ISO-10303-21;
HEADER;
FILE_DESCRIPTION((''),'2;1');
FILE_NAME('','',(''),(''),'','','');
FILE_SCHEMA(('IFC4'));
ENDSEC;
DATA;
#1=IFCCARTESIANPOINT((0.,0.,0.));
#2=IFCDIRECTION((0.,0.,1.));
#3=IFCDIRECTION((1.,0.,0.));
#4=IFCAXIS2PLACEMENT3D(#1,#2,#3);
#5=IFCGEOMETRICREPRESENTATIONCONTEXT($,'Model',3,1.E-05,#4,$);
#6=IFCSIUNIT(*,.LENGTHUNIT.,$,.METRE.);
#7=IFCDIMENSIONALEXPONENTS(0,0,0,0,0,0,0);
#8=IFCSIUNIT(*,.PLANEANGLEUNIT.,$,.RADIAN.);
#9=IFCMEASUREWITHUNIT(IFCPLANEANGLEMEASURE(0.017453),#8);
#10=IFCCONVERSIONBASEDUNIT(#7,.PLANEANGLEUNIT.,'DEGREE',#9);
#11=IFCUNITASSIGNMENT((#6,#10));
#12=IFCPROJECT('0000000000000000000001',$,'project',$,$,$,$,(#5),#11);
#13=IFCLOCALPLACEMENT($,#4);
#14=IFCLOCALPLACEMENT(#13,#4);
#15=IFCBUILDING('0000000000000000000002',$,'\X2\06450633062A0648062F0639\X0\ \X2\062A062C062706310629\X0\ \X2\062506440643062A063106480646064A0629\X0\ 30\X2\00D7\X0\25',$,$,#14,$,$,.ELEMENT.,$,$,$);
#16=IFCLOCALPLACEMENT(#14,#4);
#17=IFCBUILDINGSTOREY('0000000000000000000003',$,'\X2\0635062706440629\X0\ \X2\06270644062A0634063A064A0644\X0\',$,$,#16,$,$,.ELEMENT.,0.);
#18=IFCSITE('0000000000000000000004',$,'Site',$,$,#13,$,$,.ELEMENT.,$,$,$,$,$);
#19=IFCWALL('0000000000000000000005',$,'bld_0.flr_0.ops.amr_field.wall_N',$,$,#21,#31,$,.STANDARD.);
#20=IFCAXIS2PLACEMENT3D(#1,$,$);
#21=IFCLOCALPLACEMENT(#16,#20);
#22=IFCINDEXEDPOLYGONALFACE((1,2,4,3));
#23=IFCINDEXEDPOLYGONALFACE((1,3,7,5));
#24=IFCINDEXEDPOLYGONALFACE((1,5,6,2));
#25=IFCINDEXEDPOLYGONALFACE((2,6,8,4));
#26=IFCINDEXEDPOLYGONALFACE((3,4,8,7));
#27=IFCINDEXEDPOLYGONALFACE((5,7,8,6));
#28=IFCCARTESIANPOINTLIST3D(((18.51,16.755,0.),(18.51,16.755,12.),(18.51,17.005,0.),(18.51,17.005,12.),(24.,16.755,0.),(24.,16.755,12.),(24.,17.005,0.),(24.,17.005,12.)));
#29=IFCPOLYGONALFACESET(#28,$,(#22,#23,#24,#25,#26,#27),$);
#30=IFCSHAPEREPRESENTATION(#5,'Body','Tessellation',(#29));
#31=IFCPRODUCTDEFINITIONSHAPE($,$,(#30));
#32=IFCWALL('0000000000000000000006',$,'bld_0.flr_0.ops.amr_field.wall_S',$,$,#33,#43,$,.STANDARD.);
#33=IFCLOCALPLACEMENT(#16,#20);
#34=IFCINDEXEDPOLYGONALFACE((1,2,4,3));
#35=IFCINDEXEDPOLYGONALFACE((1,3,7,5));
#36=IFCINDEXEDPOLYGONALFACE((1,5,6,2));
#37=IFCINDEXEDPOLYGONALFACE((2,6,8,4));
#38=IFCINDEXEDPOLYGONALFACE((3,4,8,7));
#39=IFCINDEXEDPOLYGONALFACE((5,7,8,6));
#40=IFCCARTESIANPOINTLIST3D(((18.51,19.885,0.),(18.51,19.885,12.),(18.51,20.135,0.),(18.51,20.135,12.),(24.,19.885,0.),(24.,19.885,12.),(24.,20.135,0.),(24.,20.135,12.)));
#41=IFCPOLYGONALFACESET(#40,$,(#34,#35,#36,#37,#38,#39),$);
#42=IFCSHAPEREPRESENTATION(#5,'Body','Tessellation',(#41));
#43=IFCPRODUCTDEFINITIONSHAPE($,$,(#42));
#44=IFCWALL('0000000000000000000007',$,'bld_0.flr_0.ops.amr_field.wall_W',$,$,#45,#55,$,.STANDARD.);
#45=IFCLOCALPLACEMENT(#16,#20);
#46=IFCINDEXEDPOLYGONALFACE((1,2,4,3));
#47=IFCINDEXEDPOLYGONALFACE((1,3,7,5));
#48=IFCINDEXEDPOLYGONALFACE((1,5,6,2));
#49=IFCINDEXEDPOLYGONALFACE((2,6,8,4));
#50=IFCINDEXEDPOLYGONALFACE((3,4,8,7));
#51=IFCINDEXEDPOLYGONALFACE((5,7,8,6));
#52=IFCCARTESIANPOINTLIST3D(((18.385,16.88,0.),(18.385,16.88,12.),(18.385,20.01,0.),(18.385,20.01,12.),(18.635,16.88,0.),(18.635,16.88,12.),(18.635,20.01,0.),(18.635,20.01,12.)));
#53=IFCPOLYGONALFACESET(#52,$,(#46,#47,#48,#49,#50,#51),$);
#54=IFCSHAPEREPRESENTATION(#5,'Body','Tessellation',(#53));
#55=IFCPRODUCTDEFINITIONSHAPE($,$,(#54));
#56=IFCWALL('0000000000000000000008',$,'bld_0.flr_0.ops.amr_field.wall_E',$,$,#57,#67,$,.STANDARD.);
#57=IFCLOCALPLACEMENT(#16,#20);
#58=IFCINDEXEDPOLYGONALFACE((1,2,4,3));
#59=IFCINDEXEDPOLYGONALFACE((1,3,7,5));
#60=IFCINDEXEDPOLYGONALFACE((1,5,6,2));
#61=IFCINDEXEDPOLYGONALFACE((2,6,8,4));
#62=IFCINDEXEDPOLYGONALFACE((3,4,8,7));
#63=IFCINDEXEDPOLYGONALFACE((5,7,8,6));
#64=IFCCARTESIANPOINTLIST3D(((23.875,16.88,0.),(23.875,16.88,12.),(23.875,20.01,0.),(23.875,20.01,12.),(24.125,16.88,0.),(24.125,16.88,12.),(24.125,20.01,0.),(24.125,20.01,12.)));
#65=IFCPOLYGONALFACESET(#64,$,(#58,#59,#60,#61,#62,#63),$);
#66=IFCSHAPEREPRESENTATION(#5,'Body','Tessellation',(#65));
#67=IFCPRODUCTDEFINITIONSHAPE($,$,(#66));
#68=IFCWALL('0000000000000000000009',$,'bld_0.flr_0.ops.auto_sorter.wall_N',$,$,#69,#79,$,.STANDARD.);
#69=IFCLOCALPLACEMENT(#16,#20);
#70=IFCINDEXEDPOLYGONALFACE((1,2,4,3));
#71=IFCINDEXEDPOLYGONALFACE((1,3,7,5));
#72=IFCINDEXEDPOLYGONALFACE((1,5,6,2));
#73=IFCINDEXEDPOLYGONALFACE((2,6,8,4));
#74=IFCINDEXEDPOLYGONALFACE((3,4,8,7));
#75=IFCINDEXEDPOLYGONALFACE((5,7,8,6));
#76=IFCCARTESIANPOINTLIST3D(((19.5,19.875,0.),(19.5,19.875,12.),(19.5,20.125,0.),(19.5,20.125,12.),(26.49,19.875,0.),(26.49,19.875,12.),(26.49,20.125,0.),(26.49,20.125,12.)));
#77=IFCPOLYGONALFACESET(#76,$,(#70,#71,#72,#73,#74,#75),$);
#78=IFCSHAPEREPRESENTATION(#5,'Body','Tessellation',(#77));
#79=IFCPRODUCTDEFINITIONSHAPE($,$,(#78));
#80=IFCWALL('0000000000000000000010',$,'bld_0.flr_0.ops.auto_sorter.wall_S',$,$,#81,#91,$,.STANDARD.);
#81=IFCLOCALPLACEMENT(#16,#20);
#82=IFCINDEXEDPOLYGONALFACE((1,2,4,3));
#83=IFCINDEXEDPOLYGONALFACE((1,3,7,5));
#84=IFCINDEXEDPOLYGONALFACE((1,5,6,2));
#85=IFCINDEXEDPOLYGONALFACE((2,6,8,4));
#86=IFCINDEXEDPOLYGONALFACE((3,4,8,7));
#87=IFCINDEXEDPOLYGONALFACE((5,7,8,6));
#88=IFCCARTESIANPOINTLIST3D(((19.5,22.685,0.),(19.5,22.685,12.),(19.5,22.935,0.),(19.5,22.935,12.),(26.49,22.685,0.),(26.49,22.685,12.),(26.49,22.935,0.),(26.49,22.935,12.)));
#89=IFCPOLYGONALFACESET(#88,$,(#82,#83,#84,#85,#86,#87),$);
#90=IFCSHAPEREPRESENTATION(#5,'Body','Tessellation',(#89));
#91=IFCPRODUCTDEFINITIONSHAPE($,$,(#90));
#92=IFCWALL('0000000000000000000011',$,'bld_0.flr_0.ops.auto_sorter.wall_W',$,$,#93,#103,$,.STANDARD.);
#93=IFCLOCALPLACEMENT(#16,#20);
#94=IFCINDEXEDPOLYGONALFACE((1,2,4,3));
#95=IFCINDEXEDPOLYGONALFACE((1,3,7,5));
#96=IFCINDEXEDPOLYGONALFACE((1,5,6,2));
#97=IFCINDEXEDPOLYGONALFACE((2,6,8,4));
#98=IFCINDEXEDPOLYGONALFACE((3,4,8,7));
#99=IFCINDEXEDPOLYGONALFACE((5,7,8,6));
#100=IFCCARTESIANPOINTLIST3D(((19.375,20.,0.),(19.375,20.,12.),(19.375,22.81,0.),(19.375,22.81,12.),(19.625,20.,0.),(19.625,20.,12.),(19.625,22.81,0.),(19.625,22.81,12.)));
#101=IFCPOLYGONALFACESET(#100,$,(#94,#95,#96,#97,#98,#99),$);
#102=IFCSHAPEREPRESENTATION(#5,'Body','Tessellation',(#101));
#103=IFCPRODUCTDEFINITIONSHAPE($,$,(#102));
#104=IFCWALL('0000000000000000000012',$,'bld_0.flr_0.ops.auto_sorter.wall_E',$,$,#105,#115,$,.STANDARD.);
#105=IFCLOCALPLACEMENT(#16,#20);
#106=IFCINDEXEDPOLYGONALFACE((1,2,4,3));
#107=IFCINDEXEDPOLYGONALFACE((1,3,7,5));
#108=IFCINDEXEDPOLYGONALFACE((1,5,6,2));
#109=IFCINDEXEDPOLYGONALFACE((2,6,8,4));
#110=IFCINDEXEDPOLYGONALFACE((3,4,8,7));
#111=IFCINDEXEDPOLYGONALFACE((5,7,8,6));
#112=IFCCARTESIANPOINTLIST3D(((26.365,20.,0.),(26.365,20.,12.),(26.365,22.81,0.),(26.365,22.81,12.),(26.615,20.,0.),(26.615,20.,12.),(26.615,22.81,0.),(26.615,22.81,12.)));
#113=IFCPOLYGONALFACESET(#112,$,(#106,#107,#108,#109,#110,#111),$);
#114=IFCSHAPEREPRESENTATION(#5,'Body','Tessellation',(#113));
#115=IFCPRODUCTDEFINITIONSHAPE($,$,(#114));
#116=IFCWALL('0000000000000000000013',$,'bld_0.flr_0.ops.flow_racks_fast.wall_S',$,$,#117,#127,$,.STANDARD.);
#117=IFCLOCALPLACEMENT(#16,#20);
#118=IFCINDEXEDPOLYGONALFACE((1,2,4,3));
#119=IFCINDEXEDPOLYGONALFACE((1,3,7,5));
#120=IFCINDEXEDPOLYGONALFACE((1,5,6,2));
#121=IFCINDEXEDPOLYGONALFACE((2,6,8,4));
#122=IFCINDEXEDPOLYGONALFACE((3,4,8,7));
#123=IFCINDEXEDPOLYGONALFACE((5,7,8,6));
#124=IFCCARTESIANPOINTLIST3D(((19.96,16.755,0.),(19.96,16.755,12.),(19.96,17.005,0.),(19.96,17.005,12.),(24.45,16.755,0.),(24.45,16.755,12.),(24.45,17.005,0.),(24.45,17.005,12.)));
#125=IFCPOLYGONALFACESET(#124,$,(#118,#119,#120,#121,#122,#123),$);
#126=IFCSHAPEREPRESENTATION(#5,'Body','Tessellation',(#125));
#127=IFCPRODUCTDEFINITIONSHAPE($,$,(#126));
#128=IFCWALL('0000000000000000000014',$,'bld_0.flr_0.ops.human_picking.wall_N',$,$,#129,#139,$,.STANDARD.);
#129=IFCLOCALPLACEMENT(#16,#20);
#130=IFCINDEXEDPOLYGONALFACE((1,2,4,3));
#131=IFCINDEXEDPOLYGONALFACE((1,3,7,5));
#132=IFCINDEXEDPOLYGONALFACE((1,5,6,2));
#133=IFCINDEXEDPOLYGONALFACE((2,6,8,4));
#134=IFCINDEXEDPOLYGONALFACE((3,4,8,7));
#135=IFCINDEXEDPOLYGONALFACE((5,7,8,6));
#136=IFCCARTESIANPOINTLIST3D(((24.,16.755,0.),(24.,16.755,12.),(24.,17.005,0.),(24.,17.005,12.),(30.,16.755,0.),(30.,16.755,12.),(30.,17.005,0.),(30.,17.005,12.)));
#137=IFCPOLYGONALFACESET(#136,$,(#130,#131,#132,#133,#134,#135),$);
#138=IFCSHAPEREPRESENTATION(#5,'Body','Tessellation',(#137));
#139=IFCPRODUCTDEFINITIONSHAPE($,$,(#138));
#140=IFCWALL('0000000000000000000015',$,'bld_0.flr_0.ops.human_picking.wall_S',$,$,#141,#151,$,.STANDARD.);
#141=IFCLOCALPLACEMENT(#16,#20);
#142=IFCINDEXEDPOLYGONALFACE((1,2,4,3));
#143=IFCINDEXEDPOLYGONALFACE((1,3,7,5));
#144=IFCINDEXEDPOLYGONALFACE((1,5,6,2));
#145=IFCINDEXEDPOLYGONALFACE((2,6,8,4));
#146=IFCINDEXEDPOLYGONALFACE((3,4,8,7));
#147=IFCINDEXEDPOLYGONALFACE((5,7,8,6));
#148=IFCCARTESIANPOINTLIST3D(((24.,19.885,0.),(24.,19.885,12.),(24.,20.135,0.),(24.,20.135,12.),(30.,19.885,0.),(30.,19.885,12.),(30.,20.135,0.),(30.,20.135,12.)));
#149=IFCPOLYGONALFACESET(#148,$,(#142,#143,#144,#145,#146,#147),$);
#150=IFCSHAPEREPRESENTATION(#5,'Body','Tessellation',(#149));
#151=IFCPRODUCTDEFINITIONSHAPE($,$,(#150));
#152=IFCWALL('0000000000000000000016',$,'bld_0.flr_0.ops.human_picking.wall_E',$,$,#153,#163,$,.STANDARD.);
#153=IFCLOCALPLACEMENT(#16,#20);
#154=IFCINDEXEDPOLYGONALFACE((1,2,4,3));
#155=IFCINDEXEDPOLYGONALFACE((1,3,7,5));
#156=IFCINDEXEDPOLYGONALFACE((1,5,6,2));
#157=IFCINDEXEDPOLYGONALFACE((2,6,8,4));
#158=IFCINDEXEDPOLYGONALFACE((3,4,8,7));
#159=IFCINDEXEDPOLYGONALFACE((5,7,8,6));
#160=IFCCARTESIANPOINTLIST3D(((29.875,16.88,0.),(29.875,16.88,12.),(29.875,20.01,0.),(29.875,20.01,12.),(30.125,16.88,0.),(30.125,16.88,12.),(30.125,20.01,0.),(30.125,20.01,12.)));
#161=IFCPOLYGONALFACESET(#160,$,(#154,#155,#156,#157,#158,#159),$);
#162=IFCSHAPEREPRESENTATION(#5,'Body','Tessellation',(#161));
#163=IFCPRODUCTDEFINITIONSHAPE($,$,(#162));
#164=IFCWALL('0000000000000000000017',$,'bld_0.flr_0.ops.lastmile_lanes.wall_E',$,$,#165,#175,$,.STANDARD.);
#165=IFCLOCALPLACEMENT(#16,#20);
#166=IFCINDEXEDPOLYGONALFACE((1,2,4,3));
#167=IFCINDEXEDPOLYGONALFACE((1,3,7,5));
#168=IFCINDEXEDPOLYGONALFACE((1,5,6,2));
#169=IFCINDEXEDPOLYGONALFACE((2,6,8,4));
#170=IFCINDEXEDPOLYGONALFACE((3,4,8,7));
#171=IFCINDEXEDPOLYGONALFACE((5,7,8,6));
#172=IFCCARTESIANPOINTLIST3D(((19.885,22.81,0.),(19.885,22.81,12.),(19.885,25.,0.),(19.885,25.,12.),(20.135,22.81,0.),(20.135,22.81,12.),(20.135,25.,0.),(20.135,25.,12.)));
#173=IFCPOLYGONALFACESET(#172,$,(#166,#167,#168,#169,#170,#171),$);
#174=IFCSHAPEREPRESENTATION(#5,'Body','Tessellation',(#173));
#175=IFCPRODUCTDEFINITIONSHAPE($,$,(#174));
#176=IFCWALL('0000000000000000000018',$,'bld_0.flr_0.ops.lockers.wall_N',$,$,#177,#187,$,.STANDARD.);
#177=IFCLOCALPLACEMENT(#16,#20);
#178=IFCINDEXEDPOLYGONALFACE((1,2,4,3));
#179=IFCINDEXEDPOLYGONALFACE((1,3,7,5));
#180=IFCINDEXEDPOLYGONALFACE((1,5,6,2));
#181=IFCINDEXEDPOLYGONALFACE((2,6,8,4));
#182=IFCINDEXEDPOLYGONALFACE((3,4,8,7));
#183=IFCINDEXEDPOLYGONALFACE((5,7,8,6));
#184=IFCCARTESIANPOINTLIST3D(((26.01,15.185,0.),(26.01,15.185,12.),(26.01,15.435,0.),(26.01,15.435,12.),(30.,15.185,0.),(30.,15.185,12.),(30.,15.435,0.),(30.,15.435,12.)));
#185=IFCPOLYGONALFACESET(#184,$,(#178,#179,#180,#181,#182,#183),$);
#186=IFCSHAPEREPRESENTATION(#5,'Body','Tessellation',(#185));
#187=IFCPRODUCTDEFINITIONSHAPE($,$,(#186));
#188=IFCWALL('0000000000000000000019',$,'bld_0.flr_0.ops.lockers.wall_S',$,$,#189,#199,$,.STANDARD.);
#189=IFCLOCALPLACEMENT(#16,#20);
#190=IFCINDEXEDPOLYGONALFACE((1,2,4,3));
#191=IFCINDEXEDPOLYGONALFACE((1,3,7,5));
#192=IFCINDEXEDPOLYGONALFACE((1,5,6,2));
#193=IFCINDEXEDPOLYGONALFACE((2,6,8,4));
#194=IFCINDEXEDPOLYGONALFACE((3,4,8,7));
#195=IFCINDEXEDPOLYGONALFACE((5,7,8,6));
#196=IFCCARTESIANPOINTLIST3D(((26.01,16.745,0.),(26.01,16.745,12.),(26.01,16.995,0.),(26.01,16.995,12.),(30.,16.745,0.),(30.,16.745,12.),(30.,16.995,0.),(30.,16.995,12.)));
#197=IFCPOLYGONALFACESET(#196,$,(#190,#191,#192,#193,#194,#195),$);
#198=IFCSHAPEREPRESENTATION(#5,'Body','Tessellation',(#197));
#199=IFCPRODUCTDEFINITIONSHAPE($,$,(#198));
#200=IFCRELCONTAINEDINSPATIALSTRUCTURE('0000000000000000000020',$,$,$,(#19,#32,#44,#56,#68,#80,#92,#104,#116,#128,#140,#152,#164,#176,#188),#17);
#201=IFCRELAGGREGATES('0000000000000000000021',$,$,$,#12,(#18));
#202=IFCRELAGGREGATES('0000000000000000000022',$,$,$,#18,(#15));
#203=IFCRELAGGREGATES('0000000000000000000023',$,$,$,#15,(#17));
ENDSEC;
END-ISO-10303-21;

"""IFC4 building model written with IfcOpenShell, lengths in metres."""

from ifc_helpers import new_model, entity, si_unit, converted_unit, frame, frame_2d, origin_with_axes, place, context, project, spatial, rectangle, extrude, element, save


model = new_model("IFC4")

# Units and contexts
model_context = context("Model", 3, precision=1e-05, world=origin_with_axes())
ifc_project = project(units=[si_unit("LENGTHUNIT", "METRE"), converted_unit("PLANEANGLEUNIT", "DEGREE", entity("IfcPlaneAngleMeasure", 0.017453), si_unit("PLANEANGLEUNIT", "RADIAN"), dimensions=[0, 0, 0, 0, 0, 0, 0])], contexts=[model_context])

# Site, building, storey
site_placement = place(None, origin_with_axes())
site = spatial("IfcSite", under=ifc_project, at=site_placement, Name="Site", CompositionType="ELEMENT")
building_placement = place(site_placement, origin_with_axes())
building = spatial("IfcBuilding", under=site, at=building_placement, Name="مستودع تجارة إلكترونية 30×25", CompositionType="ELEMENT")
storey_placement = place(building_placement, origin_with_axes())
storey = spatial("IfcBuildingStorey", under=building, at=storey_placement, Name="صالة التشغيل", CompositionType="ELEMENT", Elevation=0.0)

# Walls
for number, where, z_axis, x_axis, name in (
    (1, (18.51, 16.88, 0.0), (0.0, 0.0, 1.0), (1.0, 0.0, 0.0), "bld_0.flr_0.ops.amr_field.wall_N"),
    (2, (18.51, 20.01, 0.0), (0.0, 0.0, 1.0), (1.0, 0.0, 0.0), "bld_0.flr_0.ops.amr_field.wall_S"),
):
    element("IfcWall", number, at=place(storey_placement, frame(where, z_axis=z_axis, x_axis=x_axis)), inside=storey, Name=name, PredefinedType="STANDARD", context=model_context, shape_type="SweptSolid", body=[
        extrude(rectangle(XDim=5.49, YDim=0.25, at=frame_2d((2.745, 0.0), x_axis=(1.0, 0.0))), origin_with_axes(), (0.0, 0.0, 1.0), 12.0),
    ])
for number, where, z_axis, x_axis, name in (
    (3, (18.51, 16.88, 0.0), (0.0, 0.0, 1.0), (0.0, 1.0, 0.0), "bld_0.flr_0.ops.amr_field.wall_W"),
    (4, (24.0, 16.88, 0.0), (0.0, 0.0, 1.0), (0.0, 1.0, 0.0), "bld_0.flr_0.ops.amr_field.wall_E"),
):
    element("IfcWall", number, at=place(storey_placement, frame(where, z_axis=z_axis, x_axis=x_axis)), inside=storey, Name=name, PredefinedType="STANDARD", context=model_context, shape_type="SweptSolid", body=[
        extrude(rectangle(XDim=3.13, YDim=0.25, at=frame_2d((1.565, 0.0), x_axis=(1.0, 0.0))), origin_with_axes(), (0.0, 0.0, 1.0), 12.0),
    ])
for number, where, z_axis, x_axis, name in (
    (5, (19.5, 20.0, 0.0), (0.0, 0.0, 1.0), (1.0, 0.0, 0.0), "bld_0.flr_0.ops.auto_sorter.wall_N"),
    (6, (19.5, 22.81, 0.0), (0.0, 0.0, 1.0), (1.0, 0.0, 0.0), "bld_0.flr_0.ops.auto_sorter.wall_S"),
):
    element("IfcWall", number, at=place(storey_placement, frame(where, z_axis=z_axis, x_axis=x_axis)), inside=storey, Name=name, PredefinedType="STANDARD", context=model_context, shape_type="SweptSolid", body=[
        extrude(rectangle(XDim=6.99, YDim=0.25, at=frame_2d((3.495, 0.0), x_axis=(1.0, 0.0))), origin_with_axes(), (0.0, 0.0, 1.0), 12.0),
    ])
for number, where, z_axis, x_axis, name in (
    (7, (19.5, 20.0, 0.0), (0.0, 0.0, 1.0), (0.0, 1.0, 0.0), "bld_0.flr_0.ops.auto_sorter.wall_W"),
    (8, (26.49, 20.0, 0.0), (0.0, 0.0, 1.0), (0.0, 1.0, 0.0), "bld_0.flr_0.ops.auto_sorter.wall_E"),
):
    element("IfcWall", number, at=place(storey_placement, frame(where, z_axis=z_axis, x_axis=x_axis)), inside=storey, Name=name, PredefinedType="STANDARD", context=model_context, shape_type="SweptSolid", body=[
        extrude(rectangle(XDim=2.81, YDim=0.25, at=frame_2d((1.405, 0.0), x_axis=(1.0, 0.0))), origin_with_axes(), (0.0, 0.0, 1.0), 12.0),
    ])
wall_1_placement = place(storey_placement, frame((19.96, 16.88, 0.0), z_axis=(0.0, 0.0, 1.0), x_axis=(1.0, 0.0, 0.0)))
element("IfcWall", 9, at=wall_1_placement, inside=storey, Name="bld_0.flr_0.ops.flow_racks_fast.wall_S", PredefinedType="STANDARD", context=model_context, shape_type="SweptSolid", body=[
    extrude(rectangle(XDim=4.49, YDim=0.25, at=frame_2d((2.245, 0.0), x_axis=(1.0, 0.0))), origin_with_axes(), (0.0, 0.0, 1.0), 12.0),
])
for number, where, z_axis, x_axis, name in (
    (10, (24.0, 16.88, 0.0), (0.0, 0.0, 1.0), (1.0, 0.0, 0.0), "bld_0.flr_0.ops.human_picking.wall_N"),
    (11, (24.0, 20.01, 0.0), (0.0, 0.0, 1.0), (1.0, 0.0, 0.0), "bld_0.flr_0.ops.human_picking.wall_S"),
):
    element("IfcWall", number, at=place(storey_placement, frame(where, z_axis=z_axis, x_axis=x_axis)), inside=storey, Name=name, PredefinedType="STANDARD", context=model_context, shape_type="SweptSolid", body=[
        extrude(rectangle(XDim=6.0, YDim=0.25, at=frame_2d((3.0, 0.0), x_axis=(1.0, 0.0))), origin_with_axes(), (0.0, 0.0, 1.0), 12.0),
    ])
for number, where, z_axis, x_axis, name in (
    (12, (30.0, 16.88, 0.0), (0.0, 0.0, 1.0), (0.0, 1.0, 0.0), "bld_0.flr_0.ops.human_picking.wall_E"),
):
    element("IfcWall", number, at=place(storey_placement, frame(where, z_axis=z_axis, x_axis=x_axis)), inside=storey, Name=name, PredefinedType="STANDARD", context=model_context, shape_type="SweptSolid", body=[
        extrude(rectangle(XDim=3.13, YDim=0.25, at=frame_2d((1.565, 0.0), x_axis=(1.0, 0.0))), origin_with_axes(), (0.0, 0.0, 1.0), 12.0),
    ])
wall_2_placement = place(storey_placement, frame((20.01, 22.81, 0.0), z_axis=(0.0, 0.0, 1.0), x_axis=(0.0, 1.0, 0.0)))
element("IfcWall", 13, at=wall_2_placement, inside=storey, Name="bld_0.flr_0.ops.lastmile_lanes.wall_E", PredefinedType="STANDARD", context=model_context, shape_type="SweptSolid", body=[
    extrude(rectangle(XDim=2.19, YDim=0.25, at=frame_2d((1.095, 0.0), x_axis=(1.0, 0.0))), origin_with_axes(), (0.0, 0.0, 1.0), 12.0),
])
for number, where, z_axis, x_axis, name in (
    (14, (26.01, 15.31, 0.0), (0.0, 0.0, 1.0), (1.0, 0.0, 0.0), "bld_0.flr_0.ops.lockers.wall_N"),
    (15, (26.01, 16.87, 0.0), (0.0, 0.0, 1.0), (1.0, 0.0, 0.0), "bld_0.flr_0.ops.lockers.wall_S"),
):
    element("IfcWall", number, at=place(storey_placement, frame(where, z_axis=z_axis, x_axis=x_axis)), inside=storey, Name=name, PredefinedType="STANDARD", context=model_context, shape_type="SweptSolid", body=[
        extrude(rectangle(XDim=3.99, YDim=0.25, at=frame_2d((1.995, 0.0), x_axis=(1.0, 0.0))), origin_with_axes(), (0.0, 0.0, 1.0), 12.0),
    ])

save(model, "model.ifc")
